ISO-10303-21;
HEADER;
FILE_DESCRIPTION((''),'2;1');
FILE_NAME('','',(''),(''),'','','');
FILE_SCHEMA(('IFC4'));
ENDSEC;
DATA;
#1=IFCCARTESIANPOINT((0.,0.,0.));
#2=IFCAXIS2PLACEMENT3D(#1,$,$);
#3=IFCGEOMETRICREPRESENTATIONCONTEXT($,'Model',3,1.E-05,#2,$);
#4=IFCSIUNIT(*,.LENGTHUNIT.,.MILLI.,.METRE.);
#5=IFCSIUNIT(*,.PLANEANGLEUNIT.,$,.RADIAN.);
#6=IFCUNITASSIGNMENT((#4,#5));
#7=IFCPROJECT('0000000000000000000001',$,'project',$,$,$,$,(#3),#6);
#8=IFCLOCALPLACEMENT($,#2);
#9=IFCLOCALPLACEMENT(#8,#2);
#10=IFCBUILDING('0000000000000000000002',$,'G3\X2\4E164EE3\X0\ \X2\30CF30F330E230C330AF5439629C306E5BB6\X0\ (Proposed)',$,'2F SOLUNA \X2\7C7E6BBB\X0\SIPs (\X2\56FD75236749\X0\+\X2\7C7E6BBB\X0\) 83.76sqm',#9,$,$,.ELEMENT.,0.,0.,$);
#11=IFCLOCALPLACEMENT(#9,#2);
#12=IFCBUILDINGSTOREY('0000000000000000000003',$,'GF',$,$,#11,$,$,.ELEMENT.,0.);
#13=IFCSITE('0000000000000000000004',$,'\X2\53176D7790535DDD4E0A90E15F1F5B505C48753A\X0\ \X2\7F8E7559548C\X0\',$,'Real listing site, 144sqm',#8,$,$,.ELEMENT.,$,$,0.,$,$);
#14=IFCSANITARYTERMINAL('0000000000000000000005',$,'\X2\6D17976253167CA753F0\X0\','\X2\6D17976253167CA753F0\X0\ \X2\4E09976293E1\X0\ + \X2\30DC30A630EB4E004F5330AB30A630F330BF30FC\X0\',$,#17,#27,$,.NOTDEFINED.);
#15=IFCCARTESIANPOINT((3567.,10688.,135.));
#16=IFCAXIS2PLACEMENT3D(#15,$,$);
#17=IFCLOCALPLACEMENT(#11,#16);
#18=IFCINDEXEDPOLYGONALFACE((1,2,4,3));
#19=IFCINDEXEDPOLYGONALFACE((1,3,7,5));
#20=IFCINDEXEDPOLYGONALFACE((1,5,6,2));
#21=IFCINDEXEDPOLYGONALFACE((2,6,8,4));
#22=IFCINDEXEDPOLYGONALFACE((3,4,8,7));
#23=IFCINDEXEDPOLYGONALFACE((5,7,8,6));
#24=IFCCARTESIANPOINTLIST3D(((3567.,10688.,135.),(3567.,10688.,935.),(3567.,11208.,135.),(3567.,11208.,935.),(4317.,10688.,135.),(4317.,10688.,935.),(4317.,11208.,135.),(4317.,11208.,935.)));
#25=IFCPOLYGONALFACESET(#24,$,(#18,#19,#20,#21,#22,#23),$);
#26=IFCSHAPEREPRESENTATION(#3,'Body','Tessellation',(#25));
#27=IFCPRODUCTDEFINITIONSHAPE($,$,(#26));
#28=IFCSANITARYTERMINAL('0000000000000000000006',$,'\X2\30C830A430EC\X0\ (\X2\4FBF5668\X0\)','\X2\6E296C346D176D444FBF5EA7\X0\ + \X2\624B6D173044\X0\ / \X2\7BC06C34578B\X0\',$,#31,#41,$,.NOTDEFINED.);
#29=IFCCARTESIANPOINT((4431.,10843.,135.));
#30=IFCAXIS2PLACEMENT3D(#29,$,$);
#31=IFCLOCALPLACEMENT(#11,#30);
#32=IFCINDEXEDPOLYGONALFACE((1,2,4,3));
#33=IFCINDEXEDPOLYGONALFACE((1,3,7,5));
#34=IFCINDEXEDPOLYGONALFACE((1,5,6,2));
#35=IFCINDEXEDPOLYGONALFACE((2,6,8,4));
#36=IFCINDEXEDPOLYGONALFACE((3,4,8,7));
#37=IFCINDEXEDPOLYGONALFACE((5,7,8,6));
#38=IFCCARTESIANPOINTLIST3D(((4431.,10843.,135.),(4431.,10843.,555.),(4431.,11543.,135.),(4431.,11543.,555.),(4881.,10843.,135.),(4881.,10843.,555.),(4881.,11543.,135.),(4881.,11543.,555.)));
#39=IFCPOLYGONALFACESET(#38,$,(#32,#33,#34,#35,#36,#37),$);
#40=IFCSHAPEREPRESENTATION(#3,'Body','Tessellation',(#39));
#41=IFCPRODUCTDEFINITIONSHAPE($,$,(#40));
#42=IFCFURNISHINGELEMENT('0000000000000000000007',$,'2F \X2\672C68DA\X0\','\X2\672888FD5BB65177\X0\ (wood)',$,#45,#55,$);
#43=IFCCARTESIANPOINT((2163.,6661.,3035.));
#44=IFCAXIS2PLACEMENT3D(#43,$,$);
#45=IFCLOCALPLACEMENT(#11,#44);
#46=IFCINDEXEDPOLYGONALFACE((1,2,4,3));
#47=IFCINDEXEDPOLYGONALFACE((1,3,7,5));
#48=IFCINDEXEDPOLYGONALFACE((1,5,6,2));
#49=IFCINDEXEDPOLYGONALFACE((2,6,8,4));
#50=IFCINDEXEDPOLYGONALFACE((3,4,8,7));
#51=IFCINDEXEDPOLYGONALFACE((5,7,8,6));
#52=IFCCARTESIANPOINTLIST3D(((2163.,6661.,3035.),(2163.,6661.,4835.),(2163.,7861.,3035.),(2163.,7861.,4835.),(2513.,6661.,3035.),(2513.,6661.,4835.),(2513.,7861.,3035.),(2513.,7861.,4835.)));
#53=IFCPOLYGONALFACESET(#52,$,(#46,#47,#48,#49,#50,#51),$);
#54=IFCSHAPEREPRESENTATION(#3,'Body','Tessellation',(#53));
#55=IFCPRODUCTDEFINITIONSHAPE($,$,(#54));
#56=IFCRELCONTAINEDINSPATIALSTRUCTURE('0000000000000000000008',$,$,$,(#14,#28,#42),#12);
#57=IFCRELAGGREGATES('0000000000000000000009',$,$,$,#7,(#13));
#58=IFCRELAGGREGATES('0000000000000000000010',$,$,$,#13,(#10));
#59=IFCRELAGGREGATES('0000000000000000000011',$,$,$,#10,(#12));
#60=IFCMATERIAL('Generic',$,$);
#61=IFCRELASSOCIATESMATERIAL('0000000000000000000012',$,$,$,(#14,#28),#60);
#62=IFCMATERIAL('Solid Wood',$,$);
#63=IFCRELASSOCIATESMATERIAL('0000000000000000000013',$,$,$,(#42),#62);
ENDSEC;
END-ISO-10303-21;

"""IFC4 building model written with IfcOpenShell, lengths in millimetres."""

from ifc_helpers import new_model, si_unit, frame, frame_2d, origin, place, context, project, spatial, rectangle, extrude, material, element, save


model = new_model("IFC4")

# Units and contexts
model_context = context("Model", 3, precision=1e-05, world=origin())
ifc_project = project(units=[si_unit("LENGTHUNIT", "METRE", prefix="MILLI"), si_unit("PLANEANGLEUNIT", "RADIAN")], contexts=[model_context])

# Site, building, storey
site_placement = place(None, origin())
site = spatial("IfcSite", under=ifc_project, at=site_placement, Name="北海道川上郡弟子屈町 美留和", ObjectType="Real listing site, 144sqm", CompositionType="ELEMENT", RefElevation=0.0)
building_placement = place(site_placement, origin())
building = spatial("IfcBuilding", under=site, at=building_placement, Name="G3世代 ハンモック吹抜の家 (Proposed)", ObjectType="2F SOLUNA 籾殻SIPs (国産杉+籾殻) 83.76sqm", CompositionType="ELEMENT", ElevationOfRefHeight=0.0, ElevationOfTerrain=0.0)
storey_placement = place(building_placement, origin())
storey = spatial("IfcBuildingStorey", under=building, at=storey_placement, Name="GF", CompositionType="ELEMENT", Elevation=0.0)

# Shared definitions
ifc_material_1 = material(Name="Solid Wood")

# Shared definitions
ifc_material_2 = material(Name="Generic")

# Sanitary terminals
sanitary_terminal_1_placement = place(storey_placement, frame((3567.0, 10688.0, 135.0)))
element("IfcSanitaryTerminal", 1, at=sanitary_terminal_1_placement, inside=storey, material=ifc_material_2, Name="洗面化粧台", Description="洗面化粧台 三面鏡 + ボウル一体カウンター", PredefinedType="NOTDEFINED", context=model_context, shape_type="SweptSolid", body=[
    extrude(rectangle(XDim=750.0, YDim=520.0, at=frame_2d((375.0, 260.0))), frame((3567.0, 10688.0, 135.0)), (0.0, 0.0, 1.0), 800.0),
])
sanitary_terminal_2_placement = place(storey_placement, frame((4431.0, 10843.0, 135.0)))
element("IfcSanitaryTerminal", 2, at=sanitary_terminal_2_placement, inside=storey, material=ifc_material_2, Name="トイレ (便器)", Description="温水洗浄便座 + 手洗い / 節水型", PredefinedType="NOTDEFINED", context=model_context, shape_type="SweptSolid", body=[
    extrude(rectangle(XDim=450.0, YDim=700.0, at=frame_2d((225.0, 350.0))), frame((4431.0, 10843.0, 135.0)), (0.0, 0.0, 1.0), 420.0),
])

# Furnishing element
furnishing_placement = place(storey_placement, frame((2163.0, 6661.0, 3035.0)))
element("IfcFurnishingElement", 3, at=furnishing_placement, inside=storey, material=ifc_material_1, Name="2F 本棚", Description="木製家具 (wood)", context=model_context, shape_type="SweptSolid", body=[
    extrude(rectangle(XDim=350.0, YDim=1200.0, at=frame_2d((175.0, 600.0))), frame((2163.0, 6661.0, 3035.0)), (0.0, 0.0, 1.0), 1800.0),
])

save(model, "model.ifc")
